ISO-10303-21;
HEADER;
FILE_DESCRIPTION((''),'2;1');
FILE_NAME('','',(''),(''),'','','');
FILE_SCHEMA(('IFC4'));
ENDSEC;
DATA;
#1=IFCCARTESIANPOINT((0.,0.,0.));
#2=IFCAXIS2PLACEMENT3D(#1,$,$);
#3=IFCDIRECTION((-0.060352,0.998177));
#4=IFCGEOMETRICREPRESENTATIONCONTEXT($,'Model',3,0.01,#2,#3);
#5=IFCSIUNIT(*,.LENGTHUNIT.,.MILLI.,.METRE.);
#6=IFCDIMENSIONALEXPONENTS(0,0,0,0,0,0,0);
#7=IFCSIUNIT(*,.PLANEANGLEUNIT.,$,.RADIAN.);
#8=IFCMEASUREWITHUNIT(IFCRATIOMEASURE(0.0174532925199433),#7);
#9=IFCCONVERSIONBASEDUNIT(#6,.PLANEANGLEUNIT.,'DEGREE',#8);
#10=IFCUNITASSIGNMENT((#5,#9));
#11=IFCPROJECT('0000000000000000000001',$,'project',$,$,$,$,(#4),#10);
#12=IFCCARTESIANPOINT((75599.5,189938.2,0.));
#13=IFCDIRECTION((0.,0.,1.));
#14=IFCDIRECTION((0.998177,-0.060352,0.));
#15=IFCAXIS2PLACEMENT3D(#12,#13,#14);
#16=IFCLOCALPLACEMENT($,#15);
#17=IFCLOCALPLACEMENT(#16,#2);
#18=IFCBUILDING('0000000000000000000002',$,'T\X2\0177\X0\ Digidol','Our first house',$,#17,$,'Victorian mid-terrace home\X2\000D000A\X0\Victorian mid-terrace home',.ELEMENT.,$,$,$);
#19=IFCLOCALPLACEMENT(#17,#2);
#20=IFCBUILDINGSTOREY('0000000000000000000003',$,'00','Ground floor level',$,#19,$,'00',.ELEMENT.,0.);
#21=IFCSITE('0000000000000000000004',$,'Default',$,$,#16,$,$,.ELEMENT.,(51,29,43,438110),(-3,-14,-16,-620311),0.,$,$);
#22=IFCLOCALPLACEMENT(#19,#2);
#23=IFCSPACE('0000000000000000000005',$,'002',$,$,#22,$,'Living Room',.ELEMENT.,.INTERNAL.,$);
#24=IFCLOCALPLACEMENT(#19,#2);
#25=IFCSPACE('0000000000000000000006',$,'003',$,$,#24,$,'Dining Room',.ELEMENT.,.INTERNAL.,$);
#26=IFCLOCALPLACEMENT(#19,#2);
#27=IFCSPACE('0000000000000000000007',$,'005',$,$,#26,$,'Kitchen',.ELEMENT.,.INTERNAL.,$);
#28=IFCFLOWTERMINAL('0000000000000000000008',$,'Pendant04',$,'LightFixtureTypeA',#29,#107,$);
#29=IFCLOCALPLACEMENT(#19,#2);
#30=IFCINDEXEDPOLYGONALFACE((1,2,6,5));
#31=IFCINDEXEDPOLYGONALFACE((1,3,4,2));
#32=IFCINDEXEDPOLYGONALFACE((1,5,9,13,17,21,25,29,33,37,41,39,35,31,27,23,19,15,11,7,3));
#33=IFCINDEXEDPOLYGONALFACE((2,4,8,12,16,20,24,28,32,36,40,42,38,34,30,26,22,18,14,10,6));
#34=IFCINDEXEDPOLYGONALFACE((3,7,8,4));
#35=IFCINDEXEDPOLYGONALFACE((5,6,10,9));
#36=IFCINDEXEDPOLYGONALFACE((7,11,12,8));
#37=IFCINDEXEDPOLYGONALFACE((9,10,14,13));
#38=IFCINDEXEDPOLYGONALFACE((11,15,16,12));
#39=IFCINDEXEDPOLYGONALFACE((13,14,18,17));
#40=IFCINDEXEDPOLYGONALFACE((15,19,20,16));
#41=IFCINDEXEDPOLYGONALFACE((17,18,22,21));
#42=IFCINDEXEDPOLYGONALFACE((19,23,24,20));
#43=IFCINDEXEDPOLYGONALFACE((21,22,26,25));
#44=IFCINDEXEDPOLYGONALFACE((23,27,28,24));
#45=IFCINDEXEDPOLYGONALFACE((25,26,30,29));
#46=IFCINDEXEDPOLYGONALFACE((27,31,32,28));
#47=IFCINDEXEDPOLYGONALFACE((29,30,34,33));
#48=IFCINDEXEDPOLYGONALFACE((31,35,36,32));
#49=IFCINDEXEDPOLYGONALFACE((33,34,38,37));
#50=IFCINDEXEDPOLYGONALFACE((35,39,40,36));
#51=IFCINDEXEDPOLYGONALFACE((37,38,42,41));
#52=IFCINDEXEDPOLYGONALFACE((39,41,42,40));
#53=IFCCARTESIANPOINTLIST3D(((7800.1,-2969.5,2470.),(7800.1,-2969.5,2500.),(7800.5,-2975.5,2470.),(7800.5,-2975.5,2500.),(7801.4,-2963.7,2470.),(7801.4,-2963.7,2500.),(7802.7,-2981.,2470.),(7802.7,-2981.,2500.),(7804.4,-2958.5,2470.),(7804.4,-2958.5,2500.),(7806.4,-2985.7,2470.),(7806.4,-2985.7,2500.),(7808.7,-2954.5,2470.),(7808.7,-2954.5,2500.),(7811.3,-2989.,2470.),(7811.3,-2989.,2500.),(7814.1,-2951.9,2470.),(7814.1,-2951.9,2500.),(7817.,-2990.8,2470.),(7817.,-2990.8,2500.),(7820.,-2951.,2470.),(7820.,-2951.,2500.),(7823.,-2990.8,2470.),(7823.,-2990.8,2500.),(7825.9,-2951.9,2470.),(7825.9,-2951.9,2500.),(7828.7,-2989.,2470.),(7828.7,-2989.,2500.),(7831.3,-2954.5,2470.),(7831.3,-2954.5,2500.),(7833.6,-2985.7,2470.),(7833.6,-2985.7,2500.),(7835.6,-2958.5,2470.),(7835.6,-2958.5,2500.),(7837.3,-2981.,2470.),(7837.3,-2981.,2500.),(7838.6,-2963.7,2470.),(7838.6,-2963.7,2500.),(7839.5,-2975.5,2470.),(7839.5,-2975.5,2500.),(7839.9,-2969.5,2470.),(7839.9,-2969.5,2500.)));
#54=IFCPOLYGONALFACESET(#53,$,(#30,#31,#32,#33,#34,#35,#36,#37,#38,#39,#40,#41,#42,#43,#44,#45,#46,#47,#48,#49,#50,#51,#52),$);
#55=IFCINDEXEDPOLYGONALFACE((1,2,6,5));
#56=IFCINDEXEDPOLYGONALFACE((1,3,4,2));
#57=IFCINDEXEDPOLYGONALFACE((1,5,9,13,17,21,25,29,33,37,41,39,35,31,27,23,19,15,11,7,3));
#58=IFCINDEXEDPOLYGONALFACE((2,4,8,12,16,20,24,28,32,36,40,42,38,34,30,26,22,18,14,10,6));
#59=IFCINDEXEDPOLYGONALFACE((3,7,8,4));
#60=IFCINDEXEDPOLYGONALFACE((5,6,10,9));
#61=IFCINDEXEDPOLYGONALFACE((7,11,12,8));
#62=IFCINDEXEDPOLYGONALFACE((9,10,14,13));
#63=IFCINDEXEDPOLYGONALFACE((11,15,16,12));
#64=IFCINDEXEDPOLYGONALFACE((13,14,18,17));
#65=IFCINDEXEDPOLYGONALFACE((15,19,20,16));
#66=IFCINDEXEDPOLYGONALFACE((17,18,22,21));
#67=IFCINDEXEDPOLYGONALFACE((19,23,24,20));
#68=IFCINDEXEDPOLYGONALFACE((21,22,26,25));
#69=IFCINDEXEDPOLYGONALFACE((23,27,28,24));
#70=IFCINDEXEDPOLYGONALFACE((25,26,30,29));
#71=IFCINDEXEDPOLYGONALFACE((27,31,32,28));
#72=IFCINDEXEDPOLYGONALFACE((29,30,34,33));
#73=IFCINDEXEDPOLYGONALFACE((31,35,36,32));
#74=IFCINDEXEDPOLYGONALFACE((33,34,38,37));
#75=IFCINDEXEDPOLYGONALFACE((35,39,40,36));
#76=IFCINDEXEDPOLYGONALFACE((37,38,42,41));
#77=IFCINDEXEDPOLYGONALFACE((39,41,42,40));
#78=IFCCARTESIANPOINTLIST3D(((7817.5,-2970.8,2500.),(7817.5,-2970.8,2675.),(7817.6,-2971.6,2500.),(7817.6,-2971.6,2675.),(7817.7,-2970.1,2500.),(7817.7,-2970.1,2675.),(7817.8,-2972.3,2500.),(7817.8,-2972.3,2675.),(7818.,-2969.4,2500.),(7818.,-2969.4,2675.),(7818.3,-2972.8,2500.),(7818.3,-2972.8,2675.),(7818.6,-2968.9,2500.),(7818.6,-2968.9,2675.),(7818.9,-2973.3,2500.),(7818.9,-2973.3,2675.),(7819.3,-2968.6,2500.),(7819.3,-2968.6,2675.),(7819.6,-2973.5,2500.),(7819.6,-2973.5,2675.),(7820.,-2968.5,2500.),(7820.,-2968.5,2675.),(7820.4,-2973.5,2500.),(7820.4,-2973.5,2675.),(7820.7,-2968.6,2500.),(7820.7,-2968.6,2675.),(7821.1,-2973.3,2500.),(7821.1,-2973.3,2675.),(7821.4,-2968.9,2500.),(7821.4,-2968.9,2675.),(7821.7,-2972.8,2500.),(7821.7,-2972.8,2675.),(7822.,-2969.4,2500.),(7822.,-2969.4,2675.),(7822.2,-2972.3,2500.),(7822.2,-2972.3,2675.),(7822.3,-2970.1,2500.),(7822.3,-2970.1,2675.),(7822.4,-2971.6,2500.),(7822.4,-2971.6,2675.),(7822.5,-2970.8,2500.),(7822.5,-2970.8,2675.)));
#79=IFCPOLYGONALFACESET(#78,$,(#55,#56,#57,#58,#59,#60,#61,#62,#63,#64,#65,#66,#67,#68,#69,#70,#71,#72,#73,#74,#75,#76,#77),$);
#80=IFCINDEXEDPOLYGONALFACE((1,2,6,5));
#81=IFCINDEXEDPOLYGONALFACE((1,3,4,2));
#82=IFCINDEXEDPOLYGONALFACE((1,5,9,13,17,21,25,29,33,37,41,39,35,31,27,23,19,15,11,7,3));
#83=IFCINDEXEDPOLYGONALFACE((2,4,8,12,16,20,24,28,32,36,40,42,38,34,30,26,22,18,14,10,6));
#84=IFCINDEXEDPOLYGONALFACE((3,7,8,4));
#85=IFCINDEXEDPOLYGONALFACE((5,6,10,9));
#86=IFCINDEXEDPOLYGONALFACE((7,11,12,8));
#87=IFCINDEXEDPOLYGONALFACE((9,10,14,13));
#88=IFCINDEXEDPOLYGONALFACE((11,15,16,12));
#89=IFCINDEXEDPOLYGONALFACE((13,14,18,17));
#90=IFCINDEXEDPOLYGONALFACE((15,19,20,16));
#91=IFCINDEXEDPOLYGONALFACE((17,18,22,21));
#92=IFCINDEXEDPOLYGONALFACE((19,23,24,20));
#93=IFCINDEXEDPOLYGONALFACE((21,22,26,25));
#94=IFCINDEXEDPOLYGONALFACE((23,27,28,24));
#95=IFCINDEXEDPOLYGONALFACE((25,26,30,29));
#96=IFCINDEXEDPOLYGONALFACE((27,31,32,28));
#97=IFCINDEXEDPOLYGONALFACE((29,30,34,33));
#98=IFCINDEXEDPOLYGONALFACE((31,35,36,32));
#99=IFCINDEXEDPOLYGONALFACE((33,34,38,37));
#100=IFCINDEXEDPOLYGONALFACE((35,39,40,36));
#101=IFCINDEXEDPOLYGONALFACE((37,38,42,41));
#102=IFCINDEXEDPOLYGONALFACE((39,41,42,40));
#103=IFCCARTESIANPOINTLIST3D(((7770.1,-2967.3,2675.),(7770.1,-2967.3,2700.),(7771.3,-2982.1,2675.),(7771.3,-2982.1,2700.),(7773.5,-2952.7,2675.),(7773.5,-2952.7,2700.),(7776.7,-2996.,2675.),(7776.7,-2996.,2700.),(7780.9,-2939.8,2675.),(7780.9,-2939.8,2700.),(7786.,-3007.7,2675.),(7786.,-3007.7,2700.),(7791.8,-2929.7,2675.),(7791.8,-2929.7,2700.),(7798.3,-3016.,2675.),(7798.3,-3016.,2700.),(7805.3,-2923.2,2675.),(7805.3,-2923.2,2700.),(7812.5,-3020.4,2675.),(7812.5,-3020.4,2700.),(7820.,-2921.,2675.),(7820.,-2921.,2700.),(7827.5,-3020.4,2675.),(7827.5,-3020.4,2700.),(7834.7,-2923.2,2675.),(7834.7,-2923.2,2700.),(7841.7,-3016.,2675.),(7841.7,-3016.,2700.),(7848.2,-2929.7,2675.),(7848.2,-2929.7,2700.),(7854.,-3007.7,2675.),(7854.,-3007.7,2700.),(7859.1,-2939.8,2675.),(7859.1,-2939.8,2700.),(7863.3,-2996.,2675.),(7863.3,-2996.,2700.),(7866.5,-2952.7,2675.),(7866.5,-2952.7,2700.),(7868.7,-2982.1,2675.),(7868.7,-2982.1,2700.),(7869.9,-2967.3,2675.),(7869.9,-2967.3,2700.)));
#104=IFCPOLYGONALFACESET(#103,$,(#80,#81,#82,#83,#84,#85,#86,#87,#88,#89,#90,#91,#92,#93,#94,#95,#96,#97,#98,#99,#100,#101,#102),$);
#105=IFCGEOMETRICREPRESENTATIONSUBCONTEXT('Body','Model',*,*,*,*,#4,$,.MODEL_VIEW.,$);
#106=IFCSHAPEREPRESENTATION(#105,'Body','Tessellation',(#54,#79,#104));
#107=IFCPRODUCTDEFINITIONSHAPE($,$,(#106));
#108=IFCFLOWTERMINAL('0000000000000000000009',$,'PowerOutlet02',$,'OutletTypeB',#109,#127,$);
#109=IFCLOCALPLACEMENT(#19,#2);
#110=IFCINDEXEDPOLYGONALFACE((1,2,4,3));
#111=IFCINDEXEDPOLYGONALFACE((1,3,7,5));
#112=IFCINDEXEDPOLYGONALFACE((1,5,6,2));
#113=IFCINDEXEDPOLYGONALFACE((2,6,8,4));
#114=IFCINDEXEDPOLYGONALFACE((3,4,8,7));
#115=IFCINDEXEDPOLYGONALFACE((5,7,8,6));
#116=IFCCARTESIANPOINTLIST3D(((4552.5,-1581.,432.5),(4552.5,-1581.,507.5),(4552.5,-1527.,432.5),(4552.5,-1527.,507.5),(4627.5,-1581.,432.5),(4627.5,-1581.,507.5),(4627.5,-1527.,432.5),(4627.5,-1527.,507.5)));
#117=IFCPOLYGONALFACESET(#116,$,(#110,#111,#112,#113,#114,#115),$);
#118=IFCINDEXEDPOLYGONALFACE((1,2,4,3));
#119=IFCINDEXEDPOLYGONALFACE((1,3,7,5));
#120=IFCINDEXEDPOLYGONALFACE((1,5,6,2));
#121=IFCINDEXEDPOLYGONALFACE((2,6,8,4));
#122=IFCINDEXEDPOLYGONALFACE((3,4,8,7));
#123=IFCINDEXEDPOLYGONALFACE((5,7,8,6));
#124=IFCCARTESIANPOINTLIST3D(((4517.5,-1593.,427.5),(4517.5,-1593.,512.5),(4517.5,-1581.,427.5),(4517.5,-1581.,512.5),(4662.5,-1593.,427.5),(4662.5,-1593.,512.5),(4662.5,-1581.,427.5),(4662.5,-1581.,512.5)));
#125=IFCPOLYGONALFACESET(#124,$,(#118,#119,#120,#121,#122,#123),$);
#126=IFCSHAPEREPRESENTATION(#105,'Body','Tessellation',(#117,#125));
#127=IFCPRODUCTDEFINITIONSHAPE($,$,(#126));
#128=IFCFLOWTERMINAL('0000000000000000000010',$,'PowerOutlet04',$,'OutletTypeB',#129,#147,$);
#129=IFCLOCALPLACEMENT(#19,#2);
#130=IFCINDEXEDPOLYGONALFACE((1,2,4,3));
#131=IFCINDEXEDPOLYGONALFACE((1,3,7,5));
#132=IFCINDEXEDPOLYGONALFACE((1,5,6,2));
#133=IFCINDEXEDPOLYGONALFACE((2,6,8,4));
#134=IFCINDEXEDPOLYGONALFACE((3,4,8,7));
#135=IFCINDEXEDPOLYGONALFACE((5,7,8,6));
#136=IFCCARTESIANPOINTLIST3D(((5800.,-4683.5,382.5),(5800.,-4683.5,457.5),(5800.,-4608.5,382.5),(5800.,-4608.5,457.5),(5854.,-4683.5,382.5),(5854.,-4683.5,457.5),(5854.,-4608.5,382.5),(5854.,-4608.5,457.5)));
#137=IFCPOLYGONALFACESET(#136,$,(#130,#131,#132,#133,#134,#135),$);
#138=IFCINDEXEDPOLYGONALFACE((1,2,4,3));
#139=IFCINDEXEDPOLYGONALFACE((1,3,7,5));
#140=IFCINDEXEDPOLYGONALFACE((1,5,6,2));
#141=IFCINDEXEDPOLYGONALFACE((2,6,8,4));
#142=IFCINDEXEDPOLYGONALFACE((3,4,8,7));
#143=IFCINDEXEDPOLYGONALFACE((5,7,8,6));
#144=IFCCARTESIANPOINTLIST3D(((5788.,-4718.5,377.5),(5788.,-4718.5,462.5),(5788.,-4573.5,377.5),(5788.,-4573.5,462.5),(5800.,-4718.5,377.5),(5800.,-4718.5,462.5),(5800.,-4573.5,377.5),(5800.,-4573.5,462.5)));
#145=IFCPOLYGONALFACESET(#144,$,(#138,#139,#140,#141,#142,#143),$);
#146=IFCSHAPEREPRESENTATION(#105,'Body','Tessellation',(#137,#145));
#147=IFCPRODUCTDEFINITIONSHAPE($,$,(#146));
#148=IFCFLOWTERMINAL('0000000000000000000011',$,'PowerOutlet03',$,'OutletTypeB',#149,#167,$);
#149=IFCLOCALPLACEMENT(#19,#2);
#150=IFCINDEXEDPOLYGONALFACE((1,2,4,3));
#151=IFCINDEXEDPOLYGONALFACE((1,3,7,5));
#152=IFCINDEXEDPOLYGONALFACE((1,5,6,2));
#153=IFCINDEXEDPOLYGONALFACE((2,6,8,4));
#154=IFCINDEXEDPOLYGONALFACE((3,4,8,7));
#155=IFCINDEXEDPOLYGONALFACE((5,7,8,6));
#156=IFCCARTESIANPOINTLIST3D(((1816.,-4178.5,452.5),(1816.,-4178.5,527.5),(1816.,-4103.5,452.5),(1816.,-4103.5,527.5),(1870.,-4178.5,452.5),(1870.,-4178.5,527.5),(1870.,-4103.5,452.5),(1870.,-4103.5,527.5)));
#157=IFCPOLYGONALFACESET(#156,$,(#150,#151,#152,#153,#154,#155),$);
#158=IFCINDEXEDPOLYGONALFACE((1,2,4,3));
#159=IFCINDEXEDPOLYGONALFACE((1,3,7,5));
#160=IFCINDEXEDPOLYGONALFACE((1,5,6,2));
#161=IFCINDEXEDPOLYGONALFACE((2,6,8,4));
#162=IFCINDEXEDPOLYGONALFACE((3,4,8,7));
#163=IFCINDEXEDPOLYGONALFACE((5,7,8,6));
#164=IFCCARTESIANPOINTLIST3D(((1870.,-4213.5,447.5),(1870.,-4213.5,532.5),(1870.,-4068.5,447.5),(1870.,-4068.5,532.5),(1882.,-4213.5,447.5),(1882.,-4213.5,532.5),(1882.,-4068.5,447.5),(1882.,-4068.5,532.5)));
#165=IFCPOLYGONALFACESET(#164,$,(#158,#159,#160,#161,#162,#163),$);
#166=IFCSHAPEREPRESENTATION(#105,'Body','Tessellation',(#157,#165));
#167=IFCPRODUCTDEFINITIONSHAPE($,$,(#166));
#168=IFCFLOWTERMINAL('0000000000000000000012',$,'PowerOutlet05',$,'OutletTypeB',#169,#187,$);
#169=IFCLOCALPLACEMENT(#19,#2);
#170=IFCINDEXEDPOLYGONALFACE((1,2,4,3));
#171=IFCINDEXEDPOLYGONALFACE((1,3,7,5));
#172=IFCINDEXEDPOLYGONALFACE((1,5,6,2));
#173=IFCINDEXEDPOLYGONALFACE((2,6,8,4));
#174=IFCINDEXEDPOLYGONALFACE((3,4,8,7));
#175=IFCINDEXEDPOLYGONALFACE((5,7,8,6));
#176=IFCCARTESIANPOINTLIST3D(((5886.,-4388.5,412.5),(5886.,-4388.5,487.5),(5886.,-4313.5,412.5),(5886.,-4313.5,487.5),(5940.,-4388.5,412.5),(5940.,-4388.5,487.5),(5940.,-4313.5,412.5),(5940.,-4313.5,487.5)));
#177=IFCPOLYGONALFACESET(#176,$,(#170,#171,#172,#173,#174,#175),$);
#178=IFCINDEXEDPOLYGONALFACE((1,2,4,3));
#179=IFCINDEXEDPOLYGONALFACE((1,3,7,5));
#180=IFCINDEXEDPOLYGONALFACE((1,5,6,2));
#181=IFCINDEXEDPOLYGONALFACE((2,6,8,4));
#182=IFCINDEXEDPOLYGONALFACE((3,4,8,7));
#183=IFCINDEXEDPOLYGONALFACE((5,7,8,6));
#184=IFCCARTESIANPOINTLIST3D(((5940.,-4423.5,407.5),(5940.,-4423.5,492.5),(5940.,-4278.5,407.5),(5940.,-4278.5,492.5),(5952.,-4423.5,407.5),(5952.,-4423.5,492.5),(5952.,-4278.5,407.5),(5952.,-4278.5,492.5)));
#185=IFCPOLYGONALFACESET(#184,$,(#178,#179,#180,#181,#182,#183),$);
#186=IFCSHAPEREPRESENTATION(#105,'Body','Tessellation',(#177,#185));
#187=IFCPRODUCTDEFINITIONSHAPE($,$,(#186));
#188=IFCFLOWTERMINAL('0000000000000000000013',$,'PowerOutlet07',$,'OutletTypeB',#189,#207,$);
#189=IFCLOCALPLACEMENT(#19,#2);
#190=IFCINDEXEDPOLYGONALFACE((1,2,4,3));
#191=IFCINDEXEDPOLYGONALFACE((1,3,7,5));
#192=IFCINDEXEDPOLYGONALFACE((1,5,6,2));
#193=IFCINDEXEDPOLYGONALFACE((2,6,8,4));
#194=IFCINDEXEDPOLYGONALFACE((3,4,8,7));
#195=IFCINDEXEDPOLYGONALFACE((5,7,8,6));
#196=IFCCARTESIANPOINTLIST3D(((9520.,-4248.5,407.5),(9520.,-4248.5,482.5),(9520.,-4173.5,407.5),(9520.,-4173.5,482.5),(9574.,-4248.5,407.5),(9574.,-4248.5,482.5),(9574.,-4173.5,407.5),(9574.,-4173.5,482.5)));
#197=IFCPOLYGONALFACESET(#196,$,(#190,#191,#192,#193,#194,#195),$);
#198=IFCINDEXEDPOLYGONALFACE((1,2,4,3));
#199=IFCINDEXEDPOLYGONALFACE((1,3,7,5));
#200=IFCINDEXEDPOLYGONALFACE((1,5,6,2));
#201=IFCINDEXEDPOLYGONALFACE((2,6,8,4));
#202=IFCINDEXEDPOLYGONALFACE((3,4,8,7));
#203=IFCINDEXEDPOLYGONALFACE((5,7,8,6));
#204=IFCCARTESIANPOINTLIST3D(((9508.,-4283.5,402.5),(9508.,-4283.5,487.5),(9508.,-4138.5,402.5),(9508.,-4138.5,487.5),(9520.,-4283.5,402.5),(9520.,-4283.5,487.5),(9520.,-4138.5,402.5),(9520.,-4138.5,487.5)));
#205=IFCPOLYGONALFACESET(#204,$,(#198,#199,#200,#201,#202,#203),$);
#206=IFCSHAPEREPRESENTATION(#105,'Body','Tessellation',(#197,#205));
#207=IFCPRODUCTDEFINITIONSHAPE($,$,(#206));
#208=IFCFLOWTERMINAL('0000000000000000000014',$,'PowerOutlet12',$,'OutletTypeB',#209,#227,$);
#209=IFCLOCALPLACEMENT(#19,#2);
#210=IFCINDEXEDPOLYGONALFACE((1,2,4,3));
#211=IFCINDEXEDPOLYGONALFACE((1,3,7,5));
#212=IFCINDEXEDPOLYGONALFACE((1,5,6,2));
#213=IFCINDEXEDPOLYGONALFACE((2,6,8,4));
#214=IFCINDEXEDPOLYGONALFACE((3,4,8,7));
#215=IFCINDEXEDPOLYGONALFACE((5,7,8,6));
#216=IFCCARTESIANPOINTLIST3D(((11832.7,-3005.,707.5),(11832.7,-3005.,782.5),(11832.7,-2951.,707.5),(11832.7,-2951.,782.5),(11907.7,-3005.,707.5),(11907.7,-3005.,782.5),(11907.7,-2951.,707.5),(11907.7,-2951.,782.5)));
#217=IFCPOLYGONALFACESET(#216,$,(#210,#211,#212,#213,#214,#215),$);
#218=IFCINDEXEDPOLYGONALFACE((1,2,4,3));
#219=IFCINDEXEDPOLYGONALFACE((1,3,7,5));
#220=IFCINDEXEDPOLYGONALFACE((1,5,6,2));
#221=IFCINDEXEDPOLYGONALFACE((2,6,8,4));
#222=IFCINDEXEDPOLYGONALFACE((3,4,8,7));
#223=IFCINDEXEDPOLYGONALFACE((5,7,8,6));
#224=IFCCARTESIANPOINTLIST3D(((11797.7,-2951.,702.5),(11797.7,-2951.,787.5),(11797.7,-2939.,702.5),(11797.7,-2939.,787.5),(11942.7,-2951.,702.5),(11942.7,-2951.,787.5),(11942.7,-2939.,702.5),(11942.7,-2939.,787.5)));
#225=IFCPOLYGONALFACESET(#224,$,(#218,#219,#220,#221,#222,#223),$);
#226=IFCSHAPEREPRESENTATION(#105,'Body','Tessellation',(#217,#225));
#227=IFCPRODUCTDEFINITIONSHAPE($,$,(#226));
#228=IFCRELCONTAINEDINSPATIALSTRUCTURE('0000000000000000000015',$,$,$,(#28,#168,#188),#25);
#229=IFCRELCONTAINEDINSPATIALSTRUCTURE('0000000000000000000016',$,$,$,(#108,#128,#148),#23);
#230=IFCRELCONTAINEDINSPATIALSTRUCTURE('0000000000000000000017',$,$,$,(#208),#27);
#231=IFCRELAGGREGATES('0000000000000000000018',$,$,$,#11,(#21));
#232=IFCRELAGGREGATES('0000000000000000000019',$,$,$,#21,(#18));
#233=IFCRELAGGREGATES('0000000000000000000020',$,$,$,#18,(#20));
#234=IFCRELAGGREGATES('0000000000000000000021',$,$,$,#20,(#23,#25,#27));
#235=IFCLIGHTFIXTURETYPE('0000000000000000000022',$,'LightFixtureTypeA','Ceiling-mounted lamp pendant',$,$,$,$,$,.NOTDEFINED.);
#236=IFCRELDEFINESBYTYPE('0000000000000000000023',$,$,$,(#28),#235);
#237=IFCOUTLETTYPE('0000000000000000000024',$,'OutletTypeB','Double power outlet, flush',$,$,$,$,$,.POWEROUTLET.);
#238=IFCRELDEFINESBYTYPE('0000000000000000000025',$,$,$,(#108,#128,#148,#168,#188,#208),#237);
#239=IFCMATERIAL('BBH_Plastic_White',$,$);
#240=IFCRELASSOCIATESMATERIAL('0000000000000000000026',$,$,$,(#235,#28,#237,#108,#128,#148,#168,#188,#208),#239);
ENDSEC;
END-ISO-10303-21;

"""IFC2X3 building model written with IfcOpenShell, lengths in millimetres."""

from ifc_helpers import new_model, entity, si_unit, converted_unit, direction, frame, frame_2d, origin, origin_2d_with_axis, place, context, subcontext, project, spatial, rectangle, circle, extrude, source, transform, mapped, material, type_object, type_shapes, element, save


model = new_model("IFC2X3")

# Units and contexts
model_context = context("Model", 3, precision=0.01, world=origin(), true_north=direction((-0.060352, 0.998177)))
body_context = subcontext(model_context, "Body", "Model", "MODEL_VIEW")
ifc_project = project(units=[si_unit("LENGTHUNIT", "METRE", prefix="MILLI"), converted_unit("PLANEANGLEUNIT", "DEGREE", entity("IfcRatioMeasure", 0.0174532925199433), si_unit("PLANEANGLEUNIT", "RADIAN"), dimensions=[0, 0, 0, 0, 0, 0, 0])], contexts=[model_context])

# Site, building, storey
site_placement = place(None, frame((75599.5, 189938.2, 0.0), z_axis=(0.0, 0.0, 1.0), x_axis=(0.998177, -0.060352, 0.0)))
site = spatial("IfcSite", under=ifc_project, at=site_placement, Name="Default", CompositionType="ELEMENT", RefLatitude=(51, 29, 43, 438110), RefLongitude=(-3, -14, -16, -620311), RefElevation=0.0)
building_placement = place(site_placement, origin())
building = spatial("IfcBuilding", under=site, at=building_placement, Name="Tŷ Digidol", Description="Our first house", LongName="Victorian mid-terrace home\r\nVictorian mid-terrace home", CompositionType="ELEMENT")
storey_placement = place(building_placement, origin())
storey = spatial("IfcBuildingStorey", under=building, at=storey_placement, Name="00", Description="Ground floor level", LongName="00", CompositionType="ELEMENT", Elevation=0.0)

# Shared definitions
space_1_placement = place(storey_placement, origin())
space_1 = spatial("IfcSpace", under=storey, at=space_1_placement, Name="002", LongName="Living Room", CompositionType="ELEMENT", InteriorOrExteriorSpace="INTERNAL")

# Shared definitions
ifc_material_1 = material(Name="BBH_Plastic_White")
light_fixture_type_1 = type_object("IfcLightFixtureType", Name="LightFixtureTypeA", Description="Ceiling-mounted lamp pendant", PredefinedType="NOTDEFINED", material=ifc_material_1)
shared_shape_1 = source(origin(), body_context, "Body", "SweptSolid", [
    extrude(circle(Radius=20.0, at=frame_2d((0.0, 0.0), x_axis=(1.0, 0.0))), frame((0.0, 0.0, 200.0)), (0.0, 0.0, 1.0), 30.0),
    extrude(circle(Radius=2.5, at=frame_2d((0.0, 0.0), x_axis=(1.0, 0.0))), frame((0.0, 0.0, 25.0)), (0.0, 0.0, 1.0), 175.0),
    extrude(circle(Radius=50.0, at=frame_2d((0.0, 0.0), x_axis=(1.0, 0.0))), origin(), (0.0, 0.0, 1.0), 25.0),
])
type_shapes(light_fixture_type_1, [shared_shape_1])

# Shared definitions
space_2_placement = place(storey_placement, origin())
space_2 = spatial("IfcSpace", under=storey, at=space_2_placement, Name="003", LongName="Dining Room", CompositionType="ELEMENT", InteriorOrExteriorSpace="INTERNAL")

# Flow terminals
flow_terminal_1_placement = place(space_2_placement, frame((7820.0, -2971.0, 2700.0), z_axis=(0.0, 0.0, -1.0), x_axis=(0.0, 1.0, 0.0)))
element("IfcFlowTerminal", 1, at=flow_terminal_1_placement, inside=space_2, type_object=light_fixture_type_1, material=ifc_material_1, Name="Pendant04", ObjectType="LightFixtureTypeA", context=body_context, shape_type="MappedRepresentation", body=[
    mapped(shared_shape_1, transform((0.0, 0.0, 0.0), scale=1.0)),
])
outlet_type_1 = type_object("IfcOutletType", Name="OutletTypeB", Description="Double power outlet, flush", PredefinedType="POWEROUTLET", material=ifc_material_1)
shared_shape_2 = source(origin(), body_context, "Body", "SweptSolid", [
    extrude(rectangle(XDim=75.0, YDim=75.0, at=origin_2d_with_axis()), frame((0.0, 0.0, -54.0), z_axis=(0.0, 0.0, 1.0), x_axis=(-1.0, 0.0, 0.0)), (0.0, 0.0, 1.0), 54.0),
    extrude(rectangle(XDim=145.0, YDim=85.0, at=origin_2d_with_axis()), frame((0.0, 0.0, 0.0), z_axis=(0.0, 0.0, 1.0), x_axis=(-1.0, 0.0, 0.0)), (0.0, 0.0, 1.0), 12.0),
])
type_shapes(outlet_type_1, [shared_shape_2])
for number, where, z_axis, x_axis, name in (
    (2, (4590.0, -1581.0, 470.0), (0.0, -1.0, 0.0), (1.0, 0.0, 0.0), "PowerOutlet02"),
    (3, (5800.0, -4646.0, 420.0), (-1.0, 0.0, 0.0), (0.0, -1.0, 0.0), "PowerOutlet04"),
    (4, (1870.0, -4141.0, 490.0), (1.0, 0.0, 0.0), (0.0, 1.0, 0.0), "PowerOutlet03"),
):
    element("IfcFlowTerminal", number, at=place(space_1_placement, frame(where, z_axis=z_axis, x_axis=x_axis)), inside=space_1, type_object=outlet_type_1, material=ifc_material_1, Name=name, ObjectType="OutletTypeB", context=body_context, shape_type="MappedRepresentation", body=[
        mapped(shared_shape_2, transform((0.0, 0.0, 0.0), scale=1.0)),
    ])
for number, where, z_axis, x_axis, name in (
    (5, (5940.0, -4351.0, 450.0), (1.0, 0.0, 0.0), (0.0, 1.0, 0.0), "PowerOutlet05"),
    (6, (9520.0, -4211.0, 445.0), (-1.0, 0.0, 0.0), (0.0, -1.0, 0.0), "PowerOutlet07"),
):
    element("IfcFlowTerminal", number, at=place(space_2_placement, frame(where, z_axis=z_axis, x_axis=x_axis)), inside=space_2, type_object=outlet_type_1, material=ifc_material_1, Name=name, ObjectType="OutletTypeB", context=body_context, shape_type="MappedRepresentation", body=[
        mapped(shared_shape_2, transform((0.0, 0.0, 0.0), scale=1.0)),
    ])

# Shared definitions
space_3_placement = place(storey_placement, origin())
space_3 = spatial("IfcSpace", under=storey, at=space_3_placement, Name="005", LongName="Kitchen", CompositionType="ELEMENT", InteriorOrExteriorSpace="INTERNAL")

# Flow terminal
for number, where, z_axis, x_axis, name in (
    (7, (11870.2, -2951.0, 745.0), (0.0, 1.0, 0.0), (-1.0, 0.0, 0.0), "PowerOutlet12"),
):
    element("IfcFlowTerminal", number, at=place(space_3_placement, frame(where, z_axis=z_axis, x_axis=x_axis)), inside=space_3, type_object=outlet_type_1, material=ifc_material_1, Name=name, ObjectType="OutletTypeB", context=body_context, shape_type="MappedRepresentation", body=[
        mapped(shared_shape_2, transform((0.0, 0.0, 0.0), scale=1.0)),
    ])

save(model, "model.ifc")
